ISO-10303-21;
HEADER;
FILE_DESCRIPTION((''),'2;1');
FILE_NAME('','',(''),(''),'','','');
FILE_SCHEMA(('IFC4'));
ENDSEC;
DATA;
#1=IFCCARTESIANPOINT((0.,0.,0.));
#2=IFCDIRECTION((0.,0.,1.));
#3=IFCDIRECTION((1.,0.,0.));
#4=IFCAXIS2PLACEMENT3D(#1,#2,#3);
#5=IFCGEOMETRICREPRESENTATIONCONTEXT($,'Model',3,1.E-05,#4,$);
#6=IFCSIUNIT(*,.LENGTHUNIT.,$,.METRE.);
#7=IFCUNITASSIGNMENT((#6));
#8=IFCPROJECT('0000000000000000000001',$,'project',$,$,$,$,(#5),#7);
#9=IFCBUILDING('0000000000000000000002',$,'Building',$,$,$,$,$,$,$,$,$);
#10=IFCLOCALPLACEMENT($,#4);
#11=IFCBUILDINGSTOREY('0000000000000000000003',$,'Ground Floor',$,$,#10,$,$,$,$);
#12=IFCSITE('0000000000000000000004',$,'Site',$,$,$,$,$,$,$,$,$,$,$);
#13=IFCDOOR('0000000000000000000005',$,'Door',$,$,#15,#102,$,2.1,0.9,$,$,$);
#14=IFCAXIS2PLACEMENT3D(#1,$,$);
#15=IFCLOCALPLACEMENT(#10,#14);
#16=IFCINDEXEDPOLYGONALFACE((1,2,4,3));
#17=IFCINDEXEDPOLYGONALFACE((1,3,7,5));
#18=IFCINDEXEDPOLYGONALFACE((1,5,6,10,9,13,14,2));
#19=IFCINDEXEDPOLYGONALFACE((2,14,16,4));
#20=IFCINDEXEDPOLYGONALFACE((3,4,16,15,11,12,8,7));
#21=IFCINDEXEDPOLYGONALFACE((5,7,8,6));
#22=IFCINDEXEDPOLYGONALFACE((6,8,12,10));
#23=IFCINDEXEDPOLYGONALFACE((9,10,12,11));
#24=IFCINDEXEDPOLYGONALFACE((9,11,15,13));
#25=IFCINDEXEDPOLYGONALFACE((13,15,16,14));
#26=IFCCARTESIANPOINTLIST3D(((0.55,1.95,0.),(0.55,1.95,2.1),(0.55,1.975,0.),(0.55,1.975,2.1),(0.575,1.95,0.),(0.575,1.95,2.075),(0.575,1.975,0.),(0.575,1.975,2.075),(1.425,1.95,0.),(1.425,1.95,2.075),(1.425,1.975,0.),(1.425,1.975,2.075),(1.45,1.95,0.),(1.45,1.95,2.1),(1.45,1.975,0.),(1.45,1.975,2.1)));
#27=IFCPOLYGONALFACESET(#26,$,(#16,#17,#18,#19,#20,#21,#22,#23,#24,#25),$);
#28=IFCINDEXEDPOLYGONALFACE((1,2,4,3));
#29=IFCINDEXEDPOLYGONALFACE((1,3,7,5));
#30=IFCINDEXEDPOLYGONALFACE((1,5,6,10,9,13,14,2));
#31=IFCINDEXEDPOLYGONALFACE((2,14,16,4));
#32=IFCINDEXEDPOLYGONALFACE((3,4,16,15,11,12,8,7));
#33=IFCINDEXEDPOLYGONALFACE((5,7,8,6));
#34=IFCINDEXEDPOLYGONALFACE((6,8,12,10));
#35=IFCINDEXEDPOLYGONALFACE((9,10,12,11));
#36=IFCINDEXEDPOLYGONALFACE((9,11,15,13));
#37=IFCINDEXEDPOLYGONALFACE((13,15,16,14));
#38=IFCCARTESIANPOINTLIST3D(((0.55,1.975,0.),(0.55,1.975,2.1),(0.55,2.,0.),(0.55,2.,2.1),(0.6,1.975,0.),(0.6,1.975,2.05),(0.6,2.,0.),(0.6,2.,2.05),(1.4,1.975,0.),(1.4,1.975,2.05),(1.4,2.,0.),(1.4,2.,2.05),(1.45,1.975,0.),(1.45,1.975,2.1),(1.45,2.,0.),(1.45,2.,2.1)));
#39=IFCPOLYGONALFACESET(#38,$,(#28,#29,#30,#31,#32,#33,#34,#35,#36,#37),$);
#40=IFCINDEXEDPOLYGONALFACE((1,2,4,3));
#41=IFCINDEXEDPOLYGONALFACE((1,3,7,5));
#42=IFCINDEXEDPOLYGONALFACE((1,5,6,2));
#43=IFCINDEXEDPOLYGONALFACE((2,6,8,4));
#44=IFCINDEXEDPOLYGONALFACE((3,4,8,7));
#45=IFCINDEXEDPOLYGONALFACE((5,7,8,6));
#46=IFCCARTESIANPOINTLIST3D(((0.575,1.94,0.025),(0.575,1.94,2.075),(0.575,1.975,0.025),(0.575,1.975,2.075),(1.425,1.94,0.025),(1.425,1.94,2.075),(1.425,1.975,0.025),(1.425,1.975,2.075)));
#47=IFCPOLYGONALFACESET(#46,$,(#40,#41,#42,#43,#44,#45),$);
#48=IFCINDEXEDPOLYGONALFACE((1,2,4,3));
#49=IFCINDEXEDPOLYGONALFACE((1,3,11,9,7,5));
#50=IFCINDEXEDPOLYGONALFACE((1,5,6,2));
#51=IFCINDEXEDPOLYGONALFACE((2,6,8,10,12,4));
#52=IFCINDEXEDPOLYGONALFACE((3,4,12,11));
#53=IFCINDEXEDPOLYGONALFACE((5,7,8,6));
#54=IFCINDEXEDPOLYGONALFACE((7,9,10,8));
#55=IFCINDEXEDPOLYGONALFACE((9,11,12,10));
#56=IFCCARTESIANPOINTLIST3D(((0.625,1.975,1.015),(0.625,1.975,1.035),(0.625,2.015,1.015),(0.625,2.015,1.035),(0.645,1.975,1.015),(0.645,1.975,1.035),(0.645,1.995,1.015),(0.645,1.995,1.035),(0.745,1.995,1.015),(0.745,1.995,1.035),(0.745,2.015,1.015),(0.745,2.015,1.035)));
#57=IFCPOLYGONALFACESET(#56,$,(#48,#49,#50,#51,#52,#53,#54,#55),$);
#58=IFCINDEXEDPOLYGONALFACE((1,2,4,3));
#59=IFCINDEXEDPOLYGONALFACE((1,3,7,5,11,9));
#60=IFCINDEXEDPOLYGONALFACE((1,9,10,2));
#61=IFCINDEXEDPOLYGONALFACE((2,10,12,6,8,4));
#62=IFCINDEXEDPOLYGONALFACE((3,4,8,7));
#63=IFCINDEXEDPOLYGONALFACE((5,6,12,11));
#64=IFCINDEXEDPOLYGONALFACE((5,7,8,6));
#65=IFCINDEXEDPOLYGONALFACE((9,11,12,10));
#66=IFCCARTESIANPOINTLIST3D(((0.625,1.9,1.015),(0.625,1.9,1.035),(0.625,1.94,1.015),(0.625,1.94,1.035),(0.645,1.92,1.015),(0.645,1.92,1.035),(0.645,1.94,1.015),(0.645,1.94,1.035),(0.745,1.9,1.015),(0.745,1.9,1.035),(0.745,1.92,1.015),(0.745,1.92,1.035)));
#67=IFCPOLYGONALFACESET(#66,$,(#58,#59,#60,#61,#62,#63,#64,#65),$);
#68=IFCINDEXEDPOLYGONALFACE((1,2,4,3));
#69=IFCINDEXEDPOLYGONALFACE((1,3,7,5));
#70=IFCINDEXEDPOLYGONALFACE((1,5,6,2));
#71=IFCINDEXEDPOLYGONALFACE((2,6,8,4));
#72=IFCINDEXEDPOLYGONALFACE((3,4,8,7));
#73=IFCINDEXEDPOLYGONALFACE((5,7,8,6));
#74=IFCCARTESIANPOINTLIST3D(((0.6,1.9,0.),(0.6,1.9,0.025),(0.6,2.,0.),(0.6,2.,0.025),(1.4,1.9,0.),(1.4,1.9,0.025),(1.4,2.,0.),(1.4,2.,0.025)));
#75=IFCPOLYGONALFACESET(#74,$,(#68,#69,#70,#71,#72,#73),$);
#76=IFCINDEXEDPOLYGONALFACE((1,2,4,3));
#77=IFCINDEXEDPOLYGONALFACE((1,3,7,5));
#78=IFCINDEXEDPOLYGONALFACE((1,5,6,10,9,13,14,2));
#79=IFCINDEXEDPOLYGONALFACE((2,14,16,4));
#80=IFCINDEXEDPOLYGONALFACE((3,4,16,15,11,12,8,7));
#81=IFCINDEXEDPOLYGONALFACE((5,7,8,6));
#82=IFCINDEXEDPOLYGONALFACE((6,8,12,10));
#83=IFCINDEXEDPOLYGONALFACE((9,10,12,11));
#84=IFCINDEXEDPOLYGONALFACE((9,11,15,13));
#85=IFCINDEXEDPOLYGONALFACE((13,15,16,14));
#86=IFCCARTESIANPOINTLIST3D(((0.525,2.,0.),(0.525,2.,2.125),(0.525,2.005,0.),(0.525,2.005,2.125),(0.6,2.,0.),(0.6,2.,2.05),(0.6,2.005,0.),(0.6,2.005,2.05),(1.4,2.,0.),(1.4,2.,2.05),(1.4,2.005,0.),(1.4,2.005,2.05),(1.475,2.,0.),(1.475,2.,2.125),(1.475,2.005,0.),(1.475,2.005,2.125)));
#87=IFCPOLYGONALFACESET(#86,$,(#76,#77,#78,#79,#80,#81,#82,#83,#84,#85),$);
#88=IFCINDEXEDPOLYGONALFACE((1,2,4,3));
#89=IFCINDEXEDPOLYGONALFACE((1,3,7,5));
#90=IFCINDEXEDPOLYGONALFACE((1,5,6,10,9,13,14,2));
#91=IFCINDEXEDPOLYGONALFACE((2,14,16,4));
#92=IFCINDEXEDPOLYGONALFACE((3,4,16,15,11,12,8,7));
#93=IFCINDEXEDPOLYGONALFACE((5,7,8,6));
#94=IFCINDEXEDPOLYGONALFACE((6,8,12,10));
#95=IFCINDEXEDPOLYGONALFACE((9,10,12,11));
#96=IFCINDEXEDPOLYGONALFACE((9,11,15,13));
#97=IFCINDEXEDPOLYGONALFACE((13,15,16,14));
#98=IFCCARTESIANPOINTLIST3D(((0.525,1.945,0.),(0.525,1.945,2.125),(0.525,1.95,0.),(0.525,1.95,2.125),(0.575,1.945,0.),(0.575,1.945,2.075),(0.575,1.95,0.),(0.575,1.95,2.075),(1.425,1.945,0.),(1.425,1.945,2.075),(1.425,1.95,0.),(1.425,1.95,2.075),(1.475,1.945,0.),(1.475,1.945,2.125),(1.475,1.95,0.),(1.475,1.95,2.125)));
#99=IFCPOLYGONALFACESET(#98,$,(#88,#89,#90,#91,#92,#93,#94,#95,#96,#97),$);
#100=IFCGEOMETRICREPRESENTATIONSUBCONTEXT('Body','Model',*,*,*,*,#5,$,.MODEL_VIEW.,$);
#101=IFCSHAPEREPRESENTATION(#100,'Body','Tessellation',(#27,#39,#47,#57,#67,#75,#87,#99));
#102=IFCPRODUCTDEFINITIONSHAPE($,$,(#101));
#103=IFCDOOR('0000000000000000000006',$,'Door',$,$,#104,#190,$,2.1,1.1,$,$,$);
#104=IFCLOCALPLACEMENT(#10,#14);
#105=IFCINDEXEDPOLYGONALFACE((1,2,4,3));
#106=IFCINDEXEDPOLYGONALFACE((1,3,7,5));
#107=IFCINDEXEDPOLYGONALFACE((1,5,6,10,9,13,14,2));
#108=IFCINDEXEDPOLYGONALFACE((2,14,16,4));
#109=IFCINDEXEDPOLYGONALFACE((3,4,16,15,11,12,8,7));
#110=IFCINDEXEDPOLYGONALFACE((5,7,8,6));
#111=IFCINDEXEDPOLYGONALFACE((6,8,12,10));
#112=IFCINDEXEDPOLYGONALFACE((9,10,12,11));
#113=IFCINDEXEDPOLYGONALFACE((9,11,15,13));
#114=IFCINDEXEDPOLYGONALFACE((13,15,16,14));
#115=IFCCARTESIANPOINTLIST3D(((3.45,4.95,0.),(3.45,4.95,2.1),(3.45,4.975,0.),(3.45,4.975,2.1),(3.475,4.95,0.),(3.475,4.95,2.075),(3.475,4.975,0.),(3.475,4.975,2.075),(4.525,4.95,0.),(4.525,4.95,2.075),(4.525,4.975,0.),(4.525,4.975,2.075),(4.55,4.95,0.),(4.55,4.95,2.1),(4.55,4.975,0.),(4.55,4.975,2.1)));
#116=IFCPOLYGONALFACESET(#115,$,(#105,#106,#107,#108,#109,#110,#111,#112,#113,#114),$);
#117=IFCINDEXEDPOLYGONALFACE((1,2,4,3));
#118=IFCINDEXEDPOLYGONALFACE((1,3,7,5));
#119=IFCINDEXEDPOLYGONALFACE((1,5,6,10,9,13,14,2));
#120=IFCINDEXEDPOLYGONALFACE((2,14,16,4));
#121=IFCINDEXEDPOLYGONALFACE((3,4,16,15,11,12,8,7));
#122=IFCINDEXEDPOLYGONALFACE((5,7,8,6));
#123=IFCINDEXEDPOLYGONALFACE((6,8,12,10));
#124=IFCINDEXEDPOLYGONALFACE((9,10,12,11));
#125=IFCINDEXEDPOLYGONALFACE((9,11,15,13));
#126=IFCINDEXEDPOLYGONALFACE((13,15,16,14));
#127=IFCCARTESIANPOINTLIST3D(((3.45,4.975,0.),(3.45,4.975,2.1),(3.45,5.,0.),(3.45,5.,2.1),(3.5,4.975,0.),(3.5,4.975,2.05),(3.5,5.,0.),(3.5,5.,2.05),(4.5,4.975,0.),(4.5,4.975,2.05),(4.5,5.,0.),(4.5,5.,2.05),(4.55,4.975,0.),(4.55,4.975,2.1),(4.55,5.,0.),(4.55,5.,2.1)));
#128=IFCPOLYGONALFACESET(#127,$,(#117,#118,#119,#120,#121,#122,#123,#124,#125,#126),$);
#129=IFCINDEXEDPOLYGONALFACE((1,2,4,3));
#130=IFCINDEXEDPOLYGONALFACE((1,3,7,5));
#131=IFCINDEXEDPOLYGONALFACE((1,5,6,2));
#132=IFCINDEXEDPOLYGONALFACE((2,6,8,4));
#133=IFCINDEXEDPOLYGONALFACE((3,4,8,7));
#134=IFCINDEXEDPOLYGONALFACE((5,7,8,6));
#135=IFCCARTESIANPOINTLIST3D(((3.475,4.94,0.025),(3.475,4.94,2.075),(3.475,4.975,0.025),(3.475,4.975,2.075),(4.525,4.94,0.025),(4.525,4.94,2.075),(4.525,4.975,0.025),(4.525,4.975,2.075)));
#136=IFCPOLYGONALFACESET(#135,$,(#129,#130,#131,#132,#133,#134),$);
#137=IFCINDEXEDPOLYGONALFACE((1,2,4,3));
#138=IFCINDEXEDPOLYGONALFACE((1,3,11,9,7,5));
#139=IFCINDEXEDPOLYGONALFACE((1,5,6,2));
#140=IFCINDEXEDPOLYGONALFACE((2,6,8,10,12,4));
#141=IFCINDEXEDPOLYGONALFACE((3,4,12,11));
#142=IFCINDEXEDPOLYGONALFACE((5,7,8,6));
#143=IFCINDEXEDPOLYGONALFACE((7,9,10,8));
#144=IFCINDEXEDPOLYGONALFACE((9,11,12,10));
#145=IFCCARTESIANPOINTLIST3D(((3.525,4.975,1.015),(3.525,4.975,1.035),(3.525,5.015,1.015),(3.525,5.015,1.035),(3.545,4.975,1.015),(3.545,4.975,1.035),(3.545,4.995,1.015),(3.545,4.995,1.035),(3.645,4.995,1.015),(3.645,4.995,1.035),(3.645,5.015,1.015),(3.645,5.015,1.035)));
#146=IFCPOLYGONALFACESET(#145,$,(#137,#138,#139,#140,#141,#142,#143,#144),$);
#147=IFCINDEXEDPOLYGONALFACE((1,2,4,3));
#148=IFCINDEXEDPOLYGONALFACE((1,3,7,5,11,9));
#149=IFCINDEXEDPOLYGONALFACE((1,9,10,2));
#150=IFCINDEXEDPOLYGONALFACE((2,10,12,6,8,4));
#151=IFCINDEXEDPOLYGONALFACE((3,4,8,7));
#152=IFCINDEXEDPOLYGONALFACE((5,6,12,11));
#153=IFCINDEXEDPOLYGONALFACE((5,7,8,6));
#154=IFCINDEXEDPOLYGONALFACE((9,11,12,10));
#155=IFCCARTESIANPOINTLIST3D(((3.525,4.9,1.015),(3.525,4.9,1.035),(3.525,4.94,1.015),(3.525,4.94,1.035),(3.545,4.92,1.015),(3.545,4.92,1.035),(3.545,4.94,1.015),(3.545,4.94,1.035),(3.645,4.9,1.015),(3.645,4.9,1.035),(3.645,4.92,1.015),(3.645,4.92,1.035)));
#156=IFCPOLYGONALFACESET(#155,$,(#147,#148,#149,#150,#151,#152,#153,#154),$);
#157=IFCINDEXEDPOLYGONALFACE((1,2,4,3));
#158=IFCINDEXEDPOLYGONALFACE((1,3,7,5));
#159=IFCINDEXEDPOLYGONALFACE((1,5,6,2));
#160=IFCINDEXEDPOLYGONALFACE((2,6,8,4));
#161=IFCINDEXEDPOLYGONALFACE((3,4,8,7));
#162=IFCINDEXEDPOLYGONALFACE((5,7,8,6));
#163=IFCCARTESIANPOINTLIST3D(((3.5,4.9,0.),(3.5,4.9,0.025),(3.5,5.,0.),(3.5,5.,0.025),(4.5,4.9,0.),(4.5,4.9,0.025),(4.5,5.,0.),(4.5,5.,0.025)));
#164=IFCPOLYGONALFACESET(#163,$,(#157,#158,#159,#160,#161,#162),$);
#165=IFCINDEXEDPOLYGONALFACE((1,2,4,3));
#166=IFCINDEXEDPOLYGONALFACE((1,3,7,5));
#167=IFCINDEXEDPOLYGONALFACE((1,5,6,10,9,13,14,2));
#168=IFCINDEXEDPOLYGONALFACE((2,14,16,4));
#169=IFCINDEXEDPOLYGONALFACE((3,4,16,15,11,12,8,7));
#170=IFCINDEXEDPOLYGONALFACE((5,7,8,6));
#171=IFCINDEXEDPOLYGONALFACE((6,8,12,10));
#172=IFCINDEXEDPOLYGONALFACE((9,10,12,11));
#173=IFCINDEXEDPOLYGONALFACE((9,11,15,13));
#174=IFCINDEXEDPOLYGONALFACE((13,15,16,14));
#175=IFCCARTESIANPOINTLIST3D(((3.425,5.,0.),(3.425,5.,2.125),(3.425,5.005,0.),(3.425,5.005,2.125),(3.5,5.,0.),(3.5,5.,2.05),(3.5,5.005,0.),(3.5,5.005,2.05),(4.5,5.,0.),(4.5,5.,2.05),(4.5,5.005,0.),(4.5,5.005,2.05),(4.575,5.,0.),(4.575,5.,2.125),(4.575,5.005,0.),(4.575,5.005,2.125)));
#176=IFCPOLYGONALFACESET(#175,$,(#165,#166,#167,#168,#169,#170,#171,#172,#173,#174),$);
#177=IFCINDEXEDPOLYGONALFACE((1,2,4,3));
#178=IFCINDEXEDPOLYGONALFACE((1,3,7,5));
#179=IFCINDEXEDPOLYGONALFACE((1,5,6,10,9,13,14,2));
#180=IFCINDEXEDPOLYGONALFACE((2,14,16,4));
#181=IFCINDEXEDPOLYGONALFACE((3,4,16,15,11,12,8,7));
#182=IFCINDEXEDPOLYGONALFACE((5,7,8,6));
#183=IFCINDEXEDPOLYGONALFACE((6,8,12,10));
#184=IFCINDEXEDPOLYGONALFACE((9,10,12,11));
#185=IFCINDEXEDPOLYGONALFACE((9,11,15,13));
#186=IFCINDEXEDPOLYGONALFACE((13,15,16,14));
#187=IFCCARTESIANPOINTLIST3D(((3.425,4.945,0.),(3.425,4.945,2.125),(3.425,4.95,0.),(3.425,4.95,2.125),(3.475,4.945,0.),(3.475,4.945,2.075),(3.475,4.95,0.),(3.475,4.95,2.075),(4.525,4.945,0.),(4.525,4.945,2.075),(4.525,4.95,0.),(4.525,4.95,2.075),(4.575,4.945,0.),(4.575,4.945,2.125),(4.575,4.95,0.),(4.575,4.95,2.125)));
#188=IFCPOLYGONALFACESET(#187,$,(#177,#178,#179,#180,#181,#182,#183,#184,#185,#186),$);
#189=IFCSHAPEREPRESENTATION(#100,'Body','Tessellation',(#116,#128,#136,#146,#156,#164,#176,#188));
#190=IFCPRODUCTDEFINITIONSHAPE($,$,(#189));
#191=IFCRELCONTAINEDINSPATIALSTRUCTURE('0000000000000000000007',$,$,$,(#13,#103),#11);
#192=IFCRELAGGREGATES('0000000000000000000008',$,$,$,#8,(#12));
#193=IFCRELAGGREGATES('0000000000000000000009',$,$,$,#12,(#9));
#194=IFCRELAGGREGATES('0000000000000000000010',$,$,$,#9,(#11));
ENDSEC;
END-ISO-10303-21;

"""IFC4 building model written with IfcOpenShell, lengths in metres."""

from ifc_helpers import new_model, si_unit, frame, origin_with_axes, place, context, subcontext, project, spatial, line, indexed_curve, outline, extrude, element, save


model = new_model("IFC4")

# Units and contexts
model_context = context("Model", 3, precision=1e-05, world=origin_with_axes())
body_context = subcontext(model_context, "Body", "Model", "MODEL_VIEW")
ifc_project = project(units=[si_unit("LENGTHUNIT", "METRE")], contexts=[model_context])

# Site, building, storey
site = spatial("IfcSite", under=ifc_project, Name="Site")
building = spatial("IfcBuilding", under=site, Name="Building")
storey_placement = place(None, origin_with_axes())
storey = spatial("IfcBuildingStorey", under=building, at=storey_placement, Name="Ground Floor")

# Doors
door_1_placement = place(storey_placement, frame((1.45, 2.0, 0.0), z_axis=(0.0, 0.0, 1.0), x_axis=(-1.0, 0.0, 0.0)))
element("IfcDoor", 1, at=door_1_placement, inside=storey, Name="Door", OverallHeight=2.1, OverallWidth=0.9, context=body_context, shape_type="SweptSolid", body=[
    extrude(outline(indexed_curve([(0.0, 0.0), (0.0, 2.1), (0.9, 2.1), (0.9, 0.0), (0.875, 0.0), (0.875, 2.075), (0.025, 2.075), (0.025, 0.0)], segments=[line(1, 2, 3, 4, 5, 6, 7, 8, 1)])), frame((0.0, 0.025, 0.0), z_axis=(0.0, -1.0, 0.0), x_axis=(1.0, 0.0, 0.0)), (0.0, 0.0, -1.0), 0.025),
    extrude(outline(indexed_curve([(0.0, 0.0), (0.0, 2.1), (0.9, 2.1), (0.9, 0.0), (0.85, 0.0), (0.85, 2.05), (0.05, 2.05), (0.05, 0.0)], segments=[line(1, 2, 3, 4, 5, 6, 7, 8, 1)])), frame((0.0, 0.0, 0.0), z_axis=(0.0, -1.0, 0.0), x_axis=(1.0, 0.0, 0.0)), (0.0, 0.0, -1.0), 0.025),
    extrude(outline(indexed_curve([(0.0, 0.0), (0.85, 0.0), (0.85, 0.035), (0.0, 0.035)], segments=[line(1, 2, 3, 4, 1)])), frame((0.025, 0.025, 0.025), z_axis=(0.0, 0.0, 1.0), x_axis=(1.0, 0.0, 0.0)), (0.0, 0.0, 1.0), 2.05),
    extrude(outline(indexed_curve([(0.0, 0.0), (0.0, -0.04), (-0.12, -0.04), (-0.12, -0.02), (-0.02, -0.02), (-0.02, 0.0)], segments=[line(1, 2, 3, 4, 5, 6, 1)])), frame((0.825, 0.025, 1.015), z_axis=(0.0, 0.0, 1.0), x_axis=(1.0, 0.0, 0.0)), (0.0, 0.0, 1.0), 0.02),
    extrude(outline(indexed_curve([(0.0, 0.0), (0.0, 0.04), (-0.12, 0.04), (-0.12, 0.02), (-0.02, 0.02), (-0.02, 0.0)], segments=[line(1, 2, 3, 4, 5, 6, 1)])), frame((0.825, 0.06, 1.015), z_axis=(0.0, 0.0, 1.0), x_axis=(1.0, 0.0, 0.0)), (0.0, 0.0, 1.0), 0.02),
    extrude(outline(indexed_curve([(0.0, 0.0), (0.8, 0.0), (0.8, 0.1), (0.0, 0.1)], segments=[line(1, 2, 3, 4, 1)])), frame((0.05, 0.0, 0.0), z_axis=(0.0, 0.0, 1.0), x_axis=(1.0, 0.0, 0.0)), (0.0, 0.0, 1.0), 0.025),
    extrude(outline(indexed_curve([(0.0, 0.0), (0.0, 2.125), (0.95, 2.125), (0.95, 0.0), (0.875, 0.0), (0.875, 2.05), (0.075, 2.05), (0.075, 0.0)], segments=[line(1, 2, 3, 4, 5, 6, 7, 8, 1)])), frame((-0.025, -0.005, 0.0), z_axis=(0.0, -1.0, 0.0), x_axis=(1.0, 0.0, 0.0)), (0.0, 0.0, -1.0), 0.005),
    extrude(outline(indexed_curve([(0.0, 0.0), (0.0, 2.125), (0.95, 2.125), (0.95, 0.0), (0.9, 0.0), (0.9, 2.075), (0.05, 2.075), (0.05, 0.0)], segments=[line(1, 2, 3, 4, 5, 6, 7, 8, 1)])), frame((-0.025, 0.05, 0.0), z_axis=(0.0, -1.0, 0.0), x_axis=(1.0, 0.0, 0.0)), (0.0, 0.0, -1.0), 0.005),
])
door_2_placement = place(storey_placement, frame((4.55, 5.0, 0.0), z_axis=(0.0, 0.0, 1.0), x_axis=(-1.0, 0.0, 0.0)))
element("IfcDoor", 2, at=door_2_placement, inside=storey, Name="Door", OverallHeight=2.1, OverallWidth=1.1, context=body_context, shape_type="SweptSolid", body=[
    extrude(outline(indexed_curve([(0.0, 0.0), (0.0, 2.1), (1.1, 2.1), (1.1, 0.0), (1.075, 0.0), (1.075, 2.075), (0.025, 2.075), (0.025, 0.0)], segments=[line(1, 2, 3, 4, 5, 6, 7, 8, 1)])), frame((0.0, 0.025, 0.0), z_axis=(0.0, -1.0, 0.0), x_axis=(1.0, 0.0, 0.0)), (0.0, 0.0, -1.0), 0.025),
    extrude(outline(indexed_curve([(0.0, 0.0), (0.0, 2.1), (1.1, 2.1), (1.1, 0.0), (1.05, 0.0), (1.05, 2.05), (0.05, 2.05), (0.05, 0.0)], segments=[line(1, 2, 3, 4, 5, 6, 7, 8, 1)])), frame((0.0, 0.0, 0.0), z_axis=(0.0, -1.0, 0.0), x_axis=(1.0, 0.0, 0.0)), (0.0, 0.0, -1.0), 0.025),
    extrude(outline(indexed_curve([(0.0, 0.0), (1.05, 0.0), (1.05, 0.035), (0.0, 0.035)], segments=[line(1, 2, 3, 4, 1)])), frame((0.025, 0.025, 0.025), z_axis=(0.0, 0.0, 1.0), x_axis=(1.0, 0.0, 0.0)), (0.0, 0.0, 1.0), 2.05),
    extrude(outline(indexed_curve([(0.0, 0.0), (0.0, -0.04), (-0.12, -0.04), (-0.12, -0.02), (-0.02, -0.02), (-0.02, 0.0)], segments=[line(1, 2, 3, 4, 5, 6, 1)])), frame((1.025, 0.025, 1.015), z_axis=(0.0, 0.0, 1.0), x_axis=(1.0, 0.0, 0.0)), (0.0, 0.0, 1.0), 0.02),
    extrude(outline(indexed_curve([(0.0, 0.0), (0.0, 0.04), (-0.12, 0.04), (-0.12, 0.02), (-0.02, 0.02), (-0.02, 0.0)], segments=[line(1, 2, 3, 4, 5, 6, 1)])), frame((1.025, 0.06, 1.015), z_axis=(0.0, 0.0, 1.0), x_axis=(1.0, 0.0, 0.0)), (0.0, 0.0, 1.0), 0.02),
    extrude(outline(indexed_curve([(0.0, 0.0), (1.0, 0.0), (1.0, 0.1), (0.0, 0.1)], segments=[line(1, 2, 3, 4, 1)])), frame((0.05, 0.0, 0.0), z_axis=(0.0, 0.0, 1.0), x_axis=(1.0, 0.0, 0.0)), (0.0, 0.0, 1.0), 0.025),
    extrude(outline(indexed_curve([(0.0, 0.0), (0.0, 2.125), (1.15, 2.125), (1.15, 0.0), (1.075, 0.0), (1.075, 2.05), (0.075, 2.05), (0.075, 0.0)], segments=[line(1, 2, 3, 4, 5, 6, 7, 8, 1)])), frame((-0.025, -0.005, 0.0), z_axis=(0.0, -1.0, 0.0), x_axis=(1.0, 0.0, 0.0)), (0.0, 0.0, -1.0), 0.005),
    extrude(outline(indexed_curve([(0.0, 0.0), (0.0, 2.125), (1.15, 2.125), (1.15, 0.0), (1.1, 0.0), (1.1, 2.075), (0.05, 2.075), (0.05, 0.0)], segments=[line(1, 2, 3, 4, 5, 6, 7, 8, 1)])), frame((-0.025, 0.05, 0.0), z_axis=(0.0, -1.0, 0.0), x_axis=(1.0, 0.0, 0.0)), (0.0, 0.0, -1.0), 0.005),
])

save(model, "model.ifc")
